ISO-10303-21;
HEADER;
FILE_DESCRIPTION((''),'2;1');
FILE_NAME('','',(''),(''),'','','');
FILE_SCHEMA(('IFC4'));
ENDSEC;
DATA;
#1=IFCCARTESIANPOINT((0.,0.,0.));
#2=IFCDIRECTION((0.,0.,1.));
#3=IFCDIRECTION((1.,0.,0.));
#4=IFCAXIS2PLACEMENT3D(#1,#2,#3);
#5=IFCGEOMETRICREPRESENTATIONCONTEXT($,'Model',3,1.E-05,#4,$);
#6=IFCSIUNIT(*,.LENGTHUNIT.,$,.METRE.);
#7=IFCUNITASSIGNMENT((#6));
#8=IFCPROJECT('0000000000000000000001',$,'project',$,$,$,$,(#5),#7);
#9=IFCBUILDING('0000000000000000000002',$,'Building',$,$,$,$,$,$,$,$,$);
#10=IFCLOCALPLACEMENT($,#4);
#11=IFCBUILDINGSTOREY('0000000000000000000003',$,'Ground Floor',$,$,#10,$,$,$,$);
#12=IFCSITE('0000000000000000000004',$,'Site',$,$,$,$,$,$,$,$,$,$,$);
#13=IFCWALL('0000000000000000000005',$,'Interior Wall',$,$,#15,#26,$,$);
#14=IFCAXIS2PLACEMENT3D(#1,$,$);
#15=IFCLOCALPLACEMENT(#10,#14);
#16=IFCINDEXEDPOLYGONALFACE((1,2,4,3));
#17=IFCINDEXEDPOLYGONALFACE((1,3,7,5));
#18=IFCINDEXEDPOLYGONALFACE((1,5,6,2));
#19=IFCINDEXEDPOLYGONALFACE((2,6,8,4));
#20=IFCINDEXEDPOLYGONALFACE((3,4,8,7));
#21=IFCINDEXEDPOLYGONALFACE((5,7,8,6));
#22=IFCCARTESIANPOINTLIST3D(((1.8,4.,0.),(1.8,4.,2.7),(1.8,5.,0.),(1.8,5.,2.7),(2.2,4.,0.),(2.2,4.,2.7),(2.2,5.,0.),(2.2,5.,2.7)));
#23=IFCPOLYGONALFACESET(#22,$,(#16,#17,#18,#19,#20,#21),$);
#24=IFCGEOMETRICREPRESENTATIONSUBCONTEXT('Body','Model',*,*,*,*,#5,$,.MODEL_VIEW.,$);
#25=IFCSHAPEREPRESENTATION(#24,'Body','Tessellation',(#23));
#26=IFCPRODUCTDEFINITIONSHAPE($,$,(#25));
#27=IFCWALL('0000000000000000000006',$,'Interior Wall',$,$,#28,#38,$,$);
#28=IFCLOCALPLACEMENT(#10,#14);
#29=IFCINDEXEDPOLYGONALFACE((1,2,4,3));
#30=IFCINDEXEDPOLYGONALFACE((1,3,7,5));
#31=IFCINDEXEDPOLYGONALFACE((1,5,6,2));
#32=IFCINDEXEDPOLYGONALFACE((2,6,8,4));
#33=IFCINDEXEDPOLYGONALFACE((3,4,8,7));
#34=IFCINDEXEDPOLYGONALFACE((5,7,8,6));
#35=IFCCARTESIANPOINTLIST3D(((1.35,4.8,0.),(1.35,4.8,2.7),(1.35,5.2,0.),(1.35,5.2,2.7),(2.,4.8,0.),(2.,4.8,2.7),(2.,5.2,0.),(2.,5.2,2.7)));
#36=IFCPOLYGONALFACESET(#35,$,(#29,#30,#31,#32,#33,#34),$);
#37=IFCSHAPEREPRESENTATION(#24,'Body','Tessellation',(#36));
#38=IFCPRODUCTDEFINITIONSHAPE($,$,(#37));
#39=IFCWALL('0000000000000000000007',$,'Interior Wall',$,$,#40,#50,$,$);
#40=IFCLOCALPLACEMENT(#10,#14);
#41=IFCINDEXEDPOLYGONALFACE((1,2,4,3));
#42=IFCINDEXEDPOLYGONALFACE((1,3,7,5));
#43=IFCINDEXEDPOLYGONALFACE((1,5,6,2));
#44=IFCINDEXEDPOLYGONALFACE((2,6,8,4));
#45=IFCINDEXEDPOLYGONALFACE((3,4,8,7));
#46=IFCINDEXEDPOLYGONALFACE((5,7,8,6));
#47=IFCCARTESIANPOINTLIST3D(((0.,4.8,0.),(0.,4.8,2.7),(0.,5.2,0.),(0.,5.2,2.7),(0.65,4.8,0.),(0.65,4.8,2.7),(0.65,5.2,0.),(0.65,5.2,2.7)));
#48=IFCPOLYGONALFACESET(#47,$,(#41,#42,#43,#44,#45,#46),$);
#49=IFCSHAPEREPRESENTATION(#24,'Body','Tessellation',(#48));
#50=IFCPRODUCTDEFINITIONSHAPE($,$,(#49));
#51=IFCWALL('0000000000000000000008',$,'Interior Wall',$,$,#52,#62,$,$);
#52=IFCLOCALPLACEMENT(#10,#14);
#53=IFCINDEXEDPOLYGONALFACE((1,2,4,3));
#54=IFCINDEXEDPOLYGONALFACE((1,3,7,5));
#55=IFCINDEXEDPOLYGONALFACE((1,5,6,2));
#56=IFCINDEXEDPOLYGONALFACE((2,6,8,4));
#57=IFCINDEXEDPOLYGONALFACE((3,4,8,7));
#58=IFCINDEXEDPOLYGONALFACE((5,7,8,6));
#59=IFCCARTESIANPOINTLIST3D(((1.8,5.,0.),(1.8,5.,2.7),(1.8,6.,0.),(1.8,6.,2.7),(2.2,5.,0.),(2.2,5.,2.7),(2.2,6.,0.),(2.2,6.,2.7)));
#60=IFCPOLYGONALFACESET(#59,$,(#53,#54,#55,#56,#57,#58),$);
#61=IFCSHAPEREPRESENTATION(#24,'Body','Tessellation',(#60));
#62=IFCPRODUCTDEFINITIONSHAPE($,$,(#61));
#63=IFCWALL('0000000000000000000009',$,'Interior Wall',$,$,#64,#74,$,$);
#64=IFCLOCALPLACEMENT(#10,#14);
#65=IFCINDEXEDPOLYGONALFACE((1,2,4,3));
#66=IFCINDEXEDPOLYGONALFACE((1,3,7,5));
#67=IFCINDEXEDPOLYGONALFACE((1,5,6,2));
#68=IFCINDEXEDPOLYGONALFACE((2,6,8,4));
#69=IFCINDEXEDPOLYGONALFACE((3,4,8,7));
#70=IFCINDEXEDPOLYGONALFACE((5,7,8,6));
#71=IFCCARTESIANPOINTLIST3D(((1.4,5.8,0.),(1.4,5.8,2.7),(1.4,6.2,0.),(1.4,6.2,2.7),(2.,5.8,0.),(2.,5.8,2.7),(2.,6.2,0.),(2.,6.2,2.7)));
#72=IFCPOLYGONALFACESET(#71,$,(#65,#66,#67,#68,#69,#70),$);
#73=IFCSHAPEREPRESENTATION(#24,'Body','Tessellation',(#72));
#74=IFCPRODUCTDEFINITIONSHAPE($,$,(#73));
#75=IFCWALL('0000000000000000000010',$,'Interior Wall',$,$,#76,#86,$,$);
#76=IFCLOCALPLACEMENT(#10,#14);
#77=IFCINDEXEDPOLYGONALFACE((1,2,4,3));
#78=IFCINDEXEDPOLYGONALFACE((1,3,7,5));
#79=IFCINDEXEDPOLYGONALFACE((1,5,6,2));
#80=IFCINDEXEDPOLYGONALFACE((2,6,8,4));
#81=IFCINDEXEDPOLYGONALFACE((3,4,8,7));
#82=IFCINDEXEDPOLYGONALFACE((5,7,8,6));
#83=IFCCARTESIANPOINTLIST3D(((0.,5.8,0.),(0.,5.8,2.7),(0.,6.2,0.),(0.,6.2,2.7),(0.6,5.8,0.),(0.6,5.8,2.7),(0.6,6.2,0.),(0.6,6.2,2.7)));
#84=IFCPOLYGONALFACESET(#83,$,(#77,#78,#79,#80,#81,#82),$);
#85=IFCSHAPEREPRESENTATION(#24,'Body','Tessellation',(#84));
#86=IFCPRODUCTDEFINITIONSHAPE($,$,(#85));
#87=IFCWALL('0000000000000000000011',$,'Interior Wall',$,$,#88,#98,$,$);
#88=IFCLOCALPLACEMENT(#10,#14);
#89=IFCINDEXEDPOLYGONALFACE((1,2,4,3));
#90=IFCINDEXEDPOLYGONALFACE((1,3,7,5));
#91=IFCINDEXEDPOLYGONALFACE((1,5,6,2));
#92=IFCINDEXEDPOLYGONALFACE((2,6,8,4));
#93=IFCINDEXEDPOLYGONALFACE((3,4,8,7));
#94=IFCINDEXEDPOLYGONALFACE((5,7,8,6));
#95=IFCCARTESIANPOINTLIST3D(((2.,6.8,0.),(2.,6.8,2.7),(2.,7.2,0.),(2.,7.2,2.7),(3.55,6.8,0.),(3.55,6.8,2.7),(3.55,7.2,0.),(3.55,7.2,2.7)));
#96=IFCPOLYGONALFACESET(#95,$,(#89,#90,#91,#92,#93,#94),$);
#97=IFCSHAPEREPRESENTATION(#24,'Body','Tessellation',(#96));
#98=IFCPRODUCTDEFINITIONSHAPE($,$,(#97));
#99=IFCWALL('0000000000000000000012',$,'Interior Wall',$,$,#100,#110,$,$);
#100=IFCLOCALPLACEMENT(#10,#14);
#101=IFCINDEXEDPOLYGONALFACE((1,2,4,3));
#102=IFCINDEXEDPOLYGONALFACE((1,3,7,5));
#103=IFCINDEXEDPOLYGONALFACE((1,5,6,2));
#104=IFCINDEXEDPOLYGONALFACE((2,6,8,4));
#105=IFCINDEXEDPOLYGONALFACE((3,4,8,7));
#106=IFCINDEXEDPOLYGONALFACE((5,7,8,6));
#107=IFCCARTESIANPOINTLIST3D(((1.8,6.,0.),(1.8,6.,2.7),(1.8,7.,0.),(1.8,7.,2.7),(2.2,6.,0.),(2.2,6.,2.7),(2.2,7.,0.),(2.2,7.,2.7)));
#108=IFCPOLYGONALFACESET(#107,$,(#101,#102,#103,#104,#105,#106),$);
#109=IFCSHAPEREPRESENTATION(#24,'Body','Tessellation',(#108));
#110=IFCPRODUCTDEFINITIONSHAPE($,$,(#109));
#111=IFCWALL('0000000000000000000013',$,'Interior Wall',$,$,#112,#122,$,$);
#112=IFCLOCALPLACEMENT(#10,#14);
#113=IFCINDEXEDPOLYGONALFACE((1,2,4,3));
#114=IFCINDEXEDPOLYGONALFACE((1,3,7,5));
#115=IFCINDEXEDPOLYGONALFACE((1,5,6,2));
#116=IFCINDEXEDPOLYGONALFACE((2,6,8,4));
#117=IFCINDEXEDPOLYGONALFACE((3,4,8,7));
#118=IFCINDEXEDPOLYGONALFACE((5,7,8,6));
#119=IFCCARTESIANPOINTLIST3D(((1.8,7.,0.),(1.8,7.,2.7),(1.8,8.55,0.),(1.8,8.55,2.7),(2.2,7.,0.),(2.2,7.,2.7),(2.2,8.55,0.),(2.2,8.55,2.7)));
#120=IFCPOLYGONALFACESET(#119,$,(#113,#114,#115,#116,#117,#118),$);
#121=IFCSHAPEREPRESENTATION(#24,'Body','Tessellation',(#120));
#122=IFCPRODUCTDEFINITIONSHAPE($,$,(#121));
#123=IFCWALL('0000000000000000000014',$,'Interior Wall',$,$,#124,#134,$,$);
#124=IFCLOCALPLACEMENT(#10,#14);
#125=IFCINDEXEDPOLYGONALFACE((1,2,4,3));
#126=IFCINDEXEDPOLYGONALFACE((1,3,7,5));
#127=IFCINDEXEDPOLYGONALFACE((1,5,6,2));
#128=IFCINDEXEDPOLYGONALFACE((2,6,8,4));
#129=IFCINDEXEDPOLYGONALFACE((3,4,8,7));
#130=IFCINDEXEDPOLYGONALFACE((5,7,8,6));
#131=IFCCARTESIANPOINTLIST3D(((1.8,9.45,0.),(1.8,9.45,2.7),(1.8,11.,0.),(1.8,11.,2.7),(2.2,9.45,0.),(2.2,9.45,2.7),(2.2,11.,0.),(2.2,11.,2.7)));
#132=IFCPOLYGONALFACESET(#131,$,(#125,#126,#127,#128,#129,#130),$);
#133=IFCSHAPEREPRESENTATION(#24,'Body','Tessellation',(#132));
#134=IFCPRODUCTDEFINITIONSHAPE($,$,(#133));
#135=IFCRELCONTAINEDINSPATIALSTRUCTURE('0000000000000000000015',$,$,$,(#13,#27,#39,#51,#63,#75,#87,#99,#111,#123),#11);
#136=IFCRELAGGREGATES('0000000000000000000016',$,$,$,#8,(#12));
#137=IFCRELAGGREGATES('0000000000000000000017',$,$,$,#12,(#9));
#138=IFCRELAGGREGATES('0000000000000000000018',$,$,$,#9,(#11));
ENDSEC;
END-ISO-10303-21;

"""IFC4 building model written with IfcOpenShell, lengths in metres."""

from ifc_helpers import new_model, si_unit, frame, origin_with_axes, place, context, subcontext, project, spatial, indexed_curve, outline, extrude, element, save


model = new_model("IFC4")

# Units and contexts
model_context = context("Model", 3, precision=1e-05, world=origin_with_axes())
body_context = subcontext(model_context, "Body", "Model", "MODEL_VIEW")
ifc_project = project(units=[si_unit("LENGTHUNIT", "METRE")], contexts=[model_context])

# Site, building, storey
site = spatial("IfcSite", under=ifc_project, Name="Site")
building = spatial("IfcBuilding", under=site, Name="Building")
storey_placement = place(None, origin_with_axes())
storey = spatial("IfcBuildingStorey", under=building, at=storey_placement, Name="Ground Floor")

# Walls
for number, where, z_axis, x_axis, name in (
    (1, (2.0, 4.0, 0.0), (0.0, 0.0, 1.0), (0.0, 1.0, 0.0), "Interior Wall"),
):
    element("IfcWall", number, at=place(storey_placement, frame(where, z_axis=z_axis, x_axis=x_axis)), inside=storey, Name=name, context=body_context, shape_type="SweptSolid", body=[
        extrude(outline(indexed_curve([(0.0, 0.0), (0.0, 0.4), (1.0, 0.4), (1.0, 0.0), (0.0, 0.0)], self_intersect=False)), frame((0.0, -0.2, 0.0), z_axis=(0.0, 0.0, 1.0), x_axis=(1.0, 0.0, 0.0)), (0.0, 0.0, 1.0), 2.7),
    ])
for number, where, z_axis, x_axis, name in (
    (2, (2.0, 5.0, 0.0), (0.0, 0.0, 1.0), (-1.0, 0.0, 0.0), "Interior Wall"),
    (3, (0.65, 5.0, 0.0), (0.0, 0.0, 1.0), (-1.0, 0.0, 0.0), "Interior Wall"),
):
    element("IfcWall", number, at=place(storey_placement, frame(where, z_axis=z_axis, x_axis=x_axis)), inside=storey, Name=name, context=body_context, shape_type="SweptSolid", body=[
        extrude(outline(indexed_curve([(0.0, 0.0), (0.0, 0.4), (0.65, 0.4), (0.65, 0.0), (0.0, 0.0)], self_intersect=False)), frame((0.0, -0.2, 0.0), z_axis=(0.0, 0.0, 1.0), x_axis=(1.0, 0.0, 0.0)), (0.0, 0.0, 1.0), 2.7),
    ])
wall_1_placement = place(storey_placement, frame((2.0, 5.0, 0.0), z_axis=(0.0, 0.0, 1.0), x_axis=(0.0, 1.0, 0.0)))
element("IfcWall", 4, at=wall_1_placement, inside=storey, Name="Interior Wall", context=body_context, shape_type="SweptSolid", body=[
    extrude(outline(indexed_curve([(0.0, 0.0), (0.0, 0.4), (1.0, 0.4), (1.0, 0.0), (0.0, 0.0)], self_intersect=False)), frame((0.0, -0.2, 0.0), z_axis=(0.0, 0.0, 1.0), x_axis=(1.0, 0.0, 0.0)), (0.0, 0.0, 1.0), 2.7),
])
for number, where, z_axis, x_axis, name in (
    (5, (2.0, 6.0, 0.0), (0.0, 0.0, 1.0), (-1.0, 0.0, 0.0), "Interior Wall"),
    (6, (0.6, 6.0, 0.0), (0.0, 0.0, 1.0), (-1.0, 0.0, 0.0), "Interior Wall"),
):
    element("IfcWall", number, at=place(storey_placement, frame(where, z_axis=z_axis, x_axis=x_axis)), inside=storey, Name=name, context=body_context, shape_type="SweptSolid", body=[
        extrude(outline(indexed_curve([(0.0, 0.0), (0.0, 0.4), (0.6, 0.4), (0.6, 0.0), (0.0, 0.0)], self_intersect=False)), frame((0.0, -0.2, 0.0), z_axis=(0.0, 0.0, 1.0), x_axis=(1.0, 0.0, 0.0)), (0.0, 0.0, 1.0), 2.7),
    ])
wall_2_placement = place(storey_placement, frame((3.55, 7.0, 0.0), z_axis=(0.0, 0.0, 1.0), x_axis=(-1.0, 0.0, 0.0)))
element("IfcWall", 7, at=wall_2_placement, inside=storey, Name="Interior Wall", context=body_context, shape_type="SweptSolid", body=[
    extrude(outline(indexed_curve([(0.0, 0.0), (0.0, 0.4), (1.55, 0.4), (1.55, 0.0), (0.0, 0.0)], self_intersect=False)), frame((0.0, -0.2, 0.0), z_axis=(0.0, 0.0, 1.0), x_axis=(1.0, 0.0, 0.0)), (0.0, 0.0, 1.0), 2.7),
])
wall_3_placement = place(storey_placement, frame((2.0, 7.0, 0.0), z_axis=(0.0, 0.0, 1.0), x_axis=(0.0, -1.0, 0.0)))
element("IfcWall", 8, at=wall_3_placement, inside=storey, Name="Interior Wall", context=body_context, shape_type="SweptSolid", body=[
    extrude(outline(indexed_curve([(0.0, 0.0), (0.0, 0.4), (1.0, 0.4), (1.0, 0.0), (0.0, 0.0)], self_intersect=False)), frame((0.0, -0.2, 0.0), z_axis=(0.0, 0.0, 1.0), x_axis=(1.0, 0.0, 0.0)), (0.0, 0.0, 1.0), 2.7),
])
for number, where, z_axis, x_axis, name in (
    (9, (2.0, 7.0, 0.0), (0.0, 0.0, 1.0), (0.0, 1.0, 0.0), "Interior Wall"),
    (10, (2.0, 9.45, 0.0), (0.0, 0.0, 1.0), (0.0, 1.0, 0.0), "Interior Wall"),
):
    element("IfcWall", number, at=place(storey_placement, frame(where, z_axis=z_axis, x_axis=x_axis)), inside=storey, Name=name, context=body_context, shape_type="SweptSolid", body=[
        extrude(outline(indexed_curve([(0.0, 0.0), (0.0, 0.4), (1.55, 0.4), (1.55, 0.0), (0.0, 0.0)], self_intersect=False)), frame((0.0, -0.2, 0.0), z_axis=(0.0, 0.0, 1.0), x_axis=(1.0, 0.0, 0.0)), (0.0, 0.0, 1.0), 2.7),
    ])

save(model, "model.ifc")
